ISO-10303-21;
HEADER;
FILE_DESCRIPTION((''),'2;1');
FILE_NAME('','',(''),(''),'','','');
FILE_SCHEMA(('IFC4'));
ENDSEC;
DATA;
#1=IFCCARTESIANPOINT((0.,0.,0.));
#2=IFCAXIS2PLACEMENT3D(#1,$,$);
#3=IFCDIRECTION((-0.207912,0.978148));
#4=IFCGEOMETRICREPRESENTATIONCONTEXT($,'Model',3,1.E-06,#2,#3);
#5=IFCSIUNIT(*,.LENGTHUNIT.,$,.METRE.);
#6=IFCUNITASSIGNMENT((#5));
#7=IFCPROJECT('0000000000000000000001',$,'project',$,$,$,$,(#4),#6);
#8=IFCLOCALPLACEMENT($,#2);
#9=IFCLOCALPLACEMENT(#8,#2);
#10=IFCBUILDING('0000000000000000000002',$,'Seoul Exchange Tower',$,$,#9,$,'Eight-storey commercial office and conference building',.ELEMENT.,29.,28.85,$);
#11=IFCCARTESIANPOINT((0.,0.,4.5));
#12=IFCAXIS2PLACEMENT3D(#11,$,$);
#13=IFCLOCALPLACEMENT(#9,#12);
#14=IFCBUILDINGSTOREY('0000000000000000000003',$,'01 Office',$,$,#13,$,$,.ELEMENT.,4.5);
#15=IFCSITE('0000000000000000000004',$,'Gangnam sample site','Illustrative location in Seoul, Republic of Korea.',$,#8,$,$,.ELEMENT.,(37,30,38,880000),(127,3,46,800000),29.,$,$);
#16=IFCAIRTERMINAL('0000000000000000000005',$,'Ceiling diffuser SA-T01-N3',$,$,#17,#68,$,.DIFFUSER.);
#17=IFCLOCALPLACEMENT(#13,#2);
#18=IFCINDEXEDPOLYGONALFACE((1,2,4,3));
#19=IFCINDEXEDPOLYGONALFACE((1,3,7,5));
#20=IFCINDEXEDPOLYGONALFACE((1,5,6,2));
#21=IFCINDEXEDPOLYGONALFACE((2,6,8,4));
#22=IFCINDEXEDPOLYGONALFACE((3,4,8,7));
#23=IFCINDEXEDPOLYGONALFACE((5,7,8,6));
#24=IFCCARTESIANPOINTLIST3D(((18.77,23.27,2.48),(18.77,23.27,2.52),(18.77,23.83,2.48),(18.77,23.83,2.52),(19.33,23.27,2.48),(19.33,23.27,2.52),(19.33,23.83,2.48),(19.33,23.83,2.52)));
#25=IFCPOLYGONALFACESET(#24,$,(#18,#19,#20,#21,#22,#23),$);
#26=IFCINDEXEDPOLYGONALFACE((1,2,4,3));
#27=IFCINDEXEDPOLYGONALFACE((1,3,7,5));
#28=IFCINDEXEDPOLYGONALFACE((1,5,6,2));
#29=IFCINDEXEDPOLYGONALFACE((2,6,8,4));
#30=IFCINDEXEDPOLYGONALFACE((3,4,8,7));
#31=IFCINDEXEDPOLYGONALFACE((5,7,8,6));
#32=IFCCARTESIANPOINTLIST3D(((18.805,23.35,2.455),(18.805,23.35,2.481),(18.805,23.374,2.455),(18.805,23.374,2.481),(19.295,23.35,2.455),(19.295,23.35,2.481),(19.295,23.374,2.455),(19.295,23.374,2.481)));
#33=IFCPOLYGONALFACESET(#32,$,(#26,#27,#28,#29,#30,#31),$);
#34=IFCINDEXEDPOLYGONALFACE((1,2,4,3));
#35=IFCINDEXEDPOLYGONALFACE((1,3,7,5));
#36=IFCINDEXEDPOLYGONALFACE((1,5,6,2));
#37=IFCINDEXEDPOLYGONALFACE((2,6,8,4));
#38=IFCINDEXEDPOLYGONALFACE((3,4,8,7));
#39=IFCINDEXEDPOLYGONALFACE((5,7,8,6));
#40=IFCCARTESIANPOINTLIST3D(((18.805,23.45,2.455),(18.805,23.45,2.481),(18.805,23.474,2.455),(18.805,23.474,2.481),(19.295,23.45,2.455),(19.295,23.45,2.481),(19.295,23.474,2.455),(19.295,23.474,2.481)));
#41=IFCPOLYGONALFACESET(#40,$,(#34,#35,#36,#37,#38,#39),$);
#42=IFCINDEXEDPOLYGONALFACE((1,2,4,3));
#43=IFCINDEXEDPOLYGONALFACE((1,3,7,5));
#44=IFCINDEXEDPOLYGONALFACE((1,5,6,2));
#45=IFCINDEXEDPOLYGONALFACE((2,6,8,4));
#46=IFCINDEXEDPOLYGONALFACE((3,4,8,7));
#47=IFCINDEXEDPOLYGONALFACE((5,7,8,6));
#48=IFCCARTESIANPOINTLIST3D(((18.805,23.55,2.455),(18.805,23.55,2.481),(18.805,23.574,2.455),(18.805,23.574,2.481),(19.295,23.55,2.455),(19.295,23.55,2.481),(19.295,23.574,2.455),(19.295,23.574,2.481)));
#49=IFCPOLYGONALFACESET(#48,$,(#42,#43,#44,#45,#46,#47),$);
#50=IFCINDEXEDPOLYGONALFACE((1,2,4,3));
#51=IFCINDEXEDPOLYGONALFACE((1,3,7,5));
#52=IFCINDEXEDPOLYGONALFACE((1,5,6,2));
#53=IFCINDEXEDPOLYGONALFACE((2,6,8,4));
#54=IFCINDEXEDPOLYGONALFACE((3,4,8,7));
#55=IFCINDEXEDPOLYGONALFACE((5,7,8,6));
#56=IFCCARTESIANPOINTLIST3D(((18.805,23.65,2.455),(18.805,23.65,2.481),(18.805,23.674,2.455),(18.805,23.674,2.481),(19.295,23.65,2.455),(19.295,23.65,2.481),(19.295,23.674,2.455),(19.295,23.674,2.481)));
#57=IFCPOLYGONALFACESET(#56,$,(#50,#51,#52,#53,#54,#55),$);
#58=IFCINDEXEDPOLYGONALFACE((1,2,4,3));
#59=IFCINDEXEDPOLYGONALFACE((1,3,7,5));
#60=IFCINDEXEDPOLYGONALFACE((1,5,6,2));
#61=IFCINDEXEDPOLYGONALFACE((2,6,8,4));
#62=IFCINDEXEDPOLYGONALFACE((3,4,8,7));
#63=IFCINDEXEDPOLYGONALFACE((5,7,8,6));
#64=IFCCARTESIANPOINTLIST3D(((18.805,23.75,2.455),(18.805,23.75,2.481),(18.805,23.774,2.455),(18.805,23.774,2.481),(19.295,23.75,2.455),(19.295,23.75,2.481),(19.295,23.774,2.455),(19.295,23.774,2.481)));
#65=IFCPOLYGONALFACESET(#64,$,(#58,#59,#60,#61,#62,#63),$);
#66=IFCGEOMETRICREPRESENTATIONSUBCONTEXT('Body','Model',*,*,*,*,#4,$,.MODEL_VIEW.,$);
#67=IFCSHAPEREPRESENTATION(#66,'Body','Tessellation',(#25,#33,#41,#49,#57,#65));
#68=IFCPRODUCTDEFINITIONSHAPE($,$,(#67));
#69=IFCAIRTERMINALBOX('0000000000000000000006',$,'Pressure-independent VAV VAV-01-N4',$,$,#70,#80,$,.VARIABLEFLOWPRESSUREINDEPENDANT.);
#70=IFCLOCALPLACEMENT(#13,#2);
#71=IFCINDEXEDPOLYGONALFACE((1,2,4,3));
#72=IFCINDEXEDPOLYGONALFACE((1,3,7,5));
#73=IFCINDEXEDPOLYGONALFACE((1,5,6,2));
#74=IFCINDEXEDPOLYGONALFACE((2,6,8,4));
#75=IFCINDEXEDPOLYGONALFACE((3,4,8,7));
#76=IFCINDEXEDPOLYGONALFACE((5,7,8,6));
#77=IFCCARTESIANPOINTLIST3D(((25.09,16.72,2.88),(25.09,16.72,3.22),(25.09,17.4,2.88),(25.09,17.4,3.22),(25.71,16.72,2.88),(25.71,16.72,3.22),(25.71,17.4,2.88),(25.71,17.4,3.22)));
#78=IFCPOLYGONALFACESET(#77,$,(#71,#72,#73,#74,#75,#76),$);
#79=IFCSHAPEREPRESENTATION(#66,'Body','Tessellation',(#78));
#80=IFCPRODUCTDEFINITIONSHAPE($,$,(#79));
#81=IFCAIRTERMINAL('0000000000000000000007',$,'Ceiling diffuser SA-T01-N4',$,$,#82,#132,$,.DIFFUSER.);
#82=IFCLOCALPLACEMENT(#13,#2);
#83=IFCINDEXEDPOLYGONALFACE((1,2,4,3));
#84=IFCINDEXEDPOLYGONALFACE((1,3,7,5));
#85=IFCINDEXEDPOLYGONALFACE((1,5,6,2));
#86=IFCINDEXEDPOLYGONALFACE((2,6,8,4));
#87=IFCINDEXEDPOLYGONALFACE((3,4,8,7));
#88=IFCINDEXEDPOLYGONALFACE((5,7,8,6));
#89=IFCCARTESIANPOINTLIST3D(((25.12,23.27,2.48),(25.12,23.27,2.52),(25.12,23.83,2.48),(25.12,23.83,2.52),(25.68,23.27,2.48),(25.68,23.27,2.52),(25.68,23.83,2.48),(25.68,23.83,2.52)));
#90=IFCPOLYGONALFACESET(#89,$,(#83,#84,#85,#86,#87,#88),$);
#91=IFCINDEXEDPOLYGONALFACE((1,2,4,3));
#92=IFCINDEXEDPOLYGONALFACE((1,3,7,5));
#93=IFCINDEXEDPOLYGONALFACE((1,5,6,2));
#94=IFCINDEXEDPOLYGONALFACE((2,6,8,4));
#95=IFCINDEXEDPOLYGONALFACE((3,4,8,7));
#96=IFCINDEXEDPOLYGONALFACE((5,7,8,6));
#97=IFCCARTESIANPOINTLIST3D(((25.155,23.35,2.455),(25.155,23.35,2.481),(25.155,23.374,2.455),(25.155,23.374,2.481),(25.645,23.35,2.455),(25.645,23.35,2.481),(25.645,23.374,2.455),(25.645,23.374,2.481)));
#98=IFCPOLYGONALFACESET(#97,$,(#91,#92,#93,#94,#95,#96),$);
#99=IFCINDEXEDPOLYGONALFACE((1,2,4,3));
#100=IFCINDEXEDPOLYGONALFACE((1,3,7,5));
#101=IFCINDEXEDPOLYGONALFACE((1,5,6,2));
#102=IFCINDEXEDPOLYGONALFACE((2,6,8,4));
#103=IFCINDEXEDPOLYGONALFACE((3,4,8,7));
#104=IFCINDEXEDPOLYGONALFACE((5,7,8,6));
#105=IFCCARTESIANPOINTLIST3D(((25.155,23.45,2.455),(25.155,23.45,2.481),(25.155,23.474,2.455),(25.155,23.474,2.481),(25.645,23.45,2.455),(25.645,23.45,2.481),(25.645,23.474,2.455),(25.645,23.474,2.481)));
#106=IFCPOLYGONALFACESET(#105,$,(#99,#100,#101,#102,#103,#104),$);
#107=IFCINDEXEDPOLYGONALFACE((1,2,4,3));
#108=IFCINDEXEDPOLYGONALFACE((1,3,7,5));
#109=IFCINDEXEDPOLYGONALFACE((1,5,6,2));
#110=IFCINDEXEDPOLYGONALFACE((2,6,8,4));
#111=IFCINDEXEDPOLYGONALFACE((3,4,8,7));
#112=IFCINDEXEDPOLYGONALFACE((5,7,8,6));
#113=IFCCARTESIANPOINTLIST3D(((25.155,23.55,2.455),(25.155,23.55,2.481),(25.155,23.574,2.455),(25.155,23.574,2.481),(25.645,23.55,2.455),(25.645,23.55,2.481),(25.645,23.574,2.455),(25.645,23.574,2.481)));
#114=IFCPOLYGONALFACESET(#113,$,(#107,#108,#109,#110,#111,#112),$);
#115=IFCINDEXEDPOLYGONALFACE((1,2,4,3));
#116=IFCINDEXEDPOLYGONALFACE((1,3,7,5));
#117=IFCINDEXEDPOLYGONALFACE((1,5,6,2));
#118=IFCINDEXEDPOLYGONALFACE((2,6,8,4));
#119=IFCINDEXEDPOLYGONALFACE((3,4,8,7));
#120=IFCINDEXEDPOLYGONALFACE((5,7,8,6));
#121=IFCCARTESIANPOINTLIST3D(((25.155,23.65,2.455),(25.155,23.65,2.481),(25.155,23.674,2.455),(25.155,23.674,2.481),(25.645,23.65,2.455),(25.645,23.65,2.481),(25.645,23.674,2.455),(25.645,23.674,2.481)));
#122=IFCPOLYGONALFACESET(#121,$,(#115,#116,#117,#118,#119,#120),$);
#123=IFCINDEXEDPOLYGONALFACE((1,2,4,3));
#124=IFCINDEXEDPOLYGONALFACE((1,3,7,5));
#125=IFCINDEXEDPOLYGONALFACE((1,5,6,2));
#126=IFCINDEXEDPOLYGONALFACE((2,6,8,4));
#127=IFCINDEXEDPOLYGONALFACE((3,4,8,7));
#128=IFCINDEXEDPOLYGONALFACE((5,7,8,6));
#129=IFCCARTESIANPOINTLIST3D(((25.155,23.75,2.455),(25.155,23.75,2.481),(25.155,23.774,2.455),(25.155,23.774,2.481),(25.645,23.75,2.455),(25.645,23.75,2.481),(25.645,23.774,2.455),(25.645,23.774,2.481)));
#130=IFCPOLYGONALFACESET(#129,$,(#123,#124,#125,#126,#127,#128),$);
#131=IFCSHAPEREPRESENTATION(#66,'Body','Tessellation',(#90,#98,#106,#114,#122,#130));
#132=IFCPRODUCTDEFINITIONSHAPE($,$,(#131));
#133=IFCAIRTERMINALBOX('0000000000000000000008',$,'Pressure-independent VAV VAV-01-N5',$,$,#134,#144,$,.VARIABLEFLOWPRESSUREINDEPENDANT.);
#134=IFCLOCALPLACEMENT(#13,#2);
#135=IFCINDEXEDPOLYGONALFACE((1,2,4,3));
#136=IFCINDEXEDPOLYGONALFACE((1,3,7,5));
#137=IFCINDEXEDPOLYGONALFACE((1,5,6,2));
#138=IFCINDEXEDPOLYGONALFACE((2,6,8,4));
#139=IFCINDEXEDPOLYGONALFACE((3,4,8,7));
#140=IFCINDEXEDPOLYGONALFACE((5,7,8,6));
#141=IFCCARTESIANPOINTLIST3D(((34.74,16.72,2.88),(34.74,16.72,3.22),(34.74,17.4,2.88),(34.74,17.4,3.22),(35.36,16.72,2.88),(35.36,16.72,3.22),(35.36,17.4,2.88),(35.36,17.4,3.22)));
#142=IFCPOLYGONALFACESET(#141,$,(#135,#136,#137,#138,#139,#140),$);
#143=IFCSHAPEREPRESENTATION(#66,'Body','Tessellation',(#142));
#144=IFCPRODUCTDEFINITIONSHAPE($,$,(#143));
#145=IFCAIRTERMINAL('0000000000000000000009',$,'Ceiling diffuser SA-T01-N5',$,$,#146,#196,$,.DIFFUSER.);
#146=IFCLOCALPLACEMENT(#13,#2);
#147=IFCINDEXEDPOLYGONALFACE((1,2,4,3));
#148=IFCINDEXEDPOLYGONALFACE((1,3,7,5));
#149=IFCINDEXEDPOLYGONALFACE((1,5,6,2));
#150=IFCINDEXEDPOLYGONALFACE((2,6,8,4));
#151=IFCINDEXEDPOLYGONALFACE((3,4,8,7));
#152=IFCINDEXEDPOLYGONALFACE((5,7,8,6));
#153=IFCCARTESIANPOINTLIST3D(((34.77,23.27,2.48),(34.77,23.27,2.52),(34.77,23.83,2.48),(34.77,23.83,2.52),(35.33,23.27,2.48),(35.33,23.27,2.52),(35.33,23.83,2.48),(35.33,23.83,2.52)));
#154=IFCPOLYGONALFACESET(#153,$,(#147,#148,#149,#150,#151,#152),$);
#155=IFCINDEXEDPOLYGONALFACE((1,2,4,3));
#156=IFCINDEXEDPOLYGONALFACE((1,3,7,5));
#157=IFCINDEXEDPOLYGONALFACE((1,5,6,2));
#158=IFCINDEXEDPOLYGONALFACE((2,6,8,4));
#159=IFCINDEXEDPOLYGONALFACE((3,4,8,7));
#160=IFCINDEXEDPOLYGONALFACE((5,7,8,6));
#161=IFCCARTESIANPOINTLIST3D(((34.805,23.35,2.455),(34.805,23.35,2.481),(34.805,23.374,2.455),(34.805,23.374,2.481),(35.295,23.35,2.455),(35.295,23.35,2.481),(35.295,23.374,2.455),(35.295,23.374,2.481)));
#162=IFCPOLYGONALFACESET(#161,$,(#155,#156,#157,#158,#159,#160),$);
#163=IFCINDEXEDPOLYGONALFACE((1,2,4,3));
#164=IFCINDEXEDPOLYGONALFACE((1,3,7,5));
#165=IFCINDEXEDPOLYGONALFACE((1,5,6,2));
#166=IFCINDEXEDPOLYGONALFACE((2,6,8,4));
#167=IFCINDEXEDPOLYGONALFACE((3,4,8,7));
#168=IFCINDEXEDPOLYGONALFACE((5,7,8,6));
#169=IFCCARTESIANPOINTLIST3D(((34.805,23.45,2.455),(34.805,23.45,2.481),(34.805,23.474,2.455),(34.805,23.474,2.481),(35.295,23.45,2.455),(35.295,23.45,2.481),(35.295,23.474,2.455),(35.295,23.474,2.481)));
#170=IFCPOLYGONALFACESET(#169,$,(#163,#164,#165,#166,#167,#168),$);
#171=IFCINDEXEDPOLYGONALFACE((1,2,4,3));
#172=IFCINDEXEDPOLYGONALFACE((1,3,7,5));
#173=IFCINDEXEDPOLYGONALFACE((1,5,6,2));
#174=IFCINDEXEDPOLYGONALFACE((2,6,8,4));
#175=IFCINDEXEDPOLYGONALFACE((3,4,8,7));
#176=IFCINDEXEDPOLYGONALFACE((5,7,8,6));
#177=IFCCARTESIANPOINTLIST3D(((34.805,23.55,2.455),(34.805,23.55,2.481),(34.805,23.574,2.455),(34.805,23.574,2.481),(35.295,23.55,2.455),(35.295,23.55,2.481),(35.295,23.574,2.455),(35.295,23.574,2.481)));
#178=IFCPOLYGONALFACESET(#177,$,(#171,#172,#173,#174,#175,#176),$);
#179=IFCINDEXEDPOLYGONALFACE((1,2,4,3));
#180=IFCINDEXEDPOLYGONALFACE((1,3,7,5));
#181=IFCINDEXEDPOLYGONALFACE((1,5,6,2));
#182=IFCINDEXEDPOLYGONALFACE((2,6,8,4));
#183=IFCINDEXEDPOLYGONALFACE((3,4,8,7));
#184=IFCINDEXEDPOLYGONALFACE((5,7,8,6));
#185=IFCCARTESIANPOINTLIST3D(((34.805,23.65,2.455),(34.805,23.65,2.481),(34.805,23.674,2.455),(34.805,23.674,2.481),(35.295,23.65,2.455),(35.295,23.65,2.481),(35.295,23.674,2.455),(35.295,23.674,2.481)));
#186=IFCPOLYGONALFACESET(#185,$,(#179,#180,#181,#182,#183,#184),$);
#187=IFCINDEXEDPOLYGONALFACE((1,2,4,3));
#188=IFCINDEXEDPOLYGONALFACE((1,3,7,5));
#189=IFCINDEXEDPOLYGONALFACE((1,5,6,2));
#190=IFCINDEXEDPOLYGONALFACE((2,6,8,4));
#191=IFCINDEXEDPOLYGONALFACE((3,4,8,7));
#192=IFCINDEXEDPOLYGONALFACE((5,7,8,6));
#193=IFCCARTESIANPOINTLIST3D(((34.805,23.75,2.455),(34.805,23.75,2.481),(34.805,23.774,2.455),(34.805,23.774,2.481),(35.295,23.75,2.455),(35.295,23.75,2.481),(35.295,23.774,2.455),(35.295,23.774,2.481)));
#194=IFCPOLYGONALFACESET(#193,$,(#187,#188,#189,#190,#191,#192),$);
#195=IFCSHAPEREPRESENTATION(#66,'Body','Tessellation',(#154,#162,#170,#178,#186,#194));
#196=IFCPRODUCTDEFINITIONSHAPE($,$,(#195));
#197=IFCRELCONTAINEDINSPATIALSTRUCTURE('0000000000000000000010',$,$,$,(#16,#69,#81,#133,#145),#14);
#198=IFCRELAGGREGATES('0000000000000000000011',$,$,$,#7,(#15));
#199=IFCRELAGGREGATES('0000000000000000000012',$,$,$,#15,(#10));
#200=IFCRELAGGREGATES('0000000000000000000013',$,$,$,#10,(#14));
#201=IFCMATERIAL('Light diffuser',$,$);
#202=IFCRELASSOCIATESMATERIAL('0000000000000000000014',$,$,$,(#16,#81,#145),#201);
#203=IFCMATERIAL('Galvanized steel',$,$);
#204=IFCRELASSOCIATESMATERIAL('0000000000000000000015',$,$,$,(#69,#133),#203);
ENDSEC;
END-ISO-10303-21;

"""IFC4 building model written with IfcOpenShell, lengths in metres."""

from ifc_helpers import new_model, si_unit, direction, frame, frame_2d, origin, place, context, subcontext, project, spatial, rectangle, extrude, material, element, save


model = new_model("IFC4")

# Units and contexts
model_context = context("Model", 3, precision=1e-06, world=origin(), true_north=direction((-0.207912, 0.978148)))
body_context = subcontext(model_context, "Body", "Model", "MODEL_VIEW")
ifc_project = project(units=[si_unit("LENGTHUNIT", "METRE")], contexts=[model_context])

# Site, building, storey
site_placement = place(None, origin())
site = spatial("IfcSite", under=ifc_project, at=site_placement, Name="Gangnam sample site", Description="Illustrative location in Seoul, Republic of Korea.", CompositionType="ELEMENT", RefLatitude=(37, 30, 38, 880000), RefLongitude=(127, 3, 46, 800000), RefElevation=29.0)
building_placement = place(site_placement, origin())
building = spatial("IfcBuilding", under=site, at=building_placement, Name="Seoul Exchange Tower", LongName="Eight-storey commercial office and conference building", CompositionType="ELEMENT", ElevationOfRefHeight=29.0, ElevationOfTerrain=28.85)
storey_placement = place(building_placement, frame((0.0, 0.0, 4.5)))
storey = spatial("IfcBuildingStorey", under=building, at=storey_placement, Name="01 Office", CompositionType="ELEMENT", Elevation=4.5)

# Shared definitions
placement = place(storey_placement, origin())

# Shared definitions
ifc_material_1 = material(Name="Galvanized steel")

# Shared definitions
ifc_material_2 = material(Name="Light diffuser")

# Air terminal
element("IfcAirTerminal", 1, at=placement, inside=storey, material=ifc_material_2, Name="Ceiling diffuser SA-T01-N3", PredefinedType="DIFFUSER", context=body_context, shape_type="SweptSolid", body=[
    extrude(rectangle(XDim=0.56, YDim=0.56, at=frame_2d((0.28, 0.28))), frame((18.77, 23.27, 2.48)), (0.0, 0.0, 1.0), 0.04),
    extrude(rectangle(XDim=0.49, YDim=0.024, at=frame_2d((0.245, 0.012))), frame((18.805, 23.35, 2.455)), (0.0, 0.0, 1.0), 0.026),
    extrude(rectangle(XDim=0.49, YDim=0.024, at=frame_2d((0.245, 0.012))), frame((18.805, 23.45, 2.455)), (0.0, 0.0, 1.0), 0.026),
    extrude(rectangle(XDim=0.49, YDim=0.024, at=frame_2d((0.245, 0.012))), frame((18.805, 23.55, 2.455)), (0.0, 0.0, 1.0), 0.026),
    extrude(rectangle(XDim=0.49, YDim=0.024, at=frame_2d((0.245, 0.012))), frame((18.805, 23.65, 2.455)), (0.0, 0.0, 1.0), 0.026),
    extrude(rectangle(XDim=0.49, YDim=0.024, at=frame_2d((0.245, 0.012))), frame((18.805, 23.75, 2.455)), (0.0, 0.0, 1.0), 0.026),
])

# Air terminal box
element("IfcAirTerminalBox", 2, at=placement, inside=storey, material=ifc_material_1, Name="Pressure-independent VAV VAV-01-N4", PredefinedType="VARIABLEFLOWPRESSUREINDEPENDANT", context=body_context, shape_type="SweptSolid", body=[
    extrude(rectangle(XDim=0.62, YDim=0.68, at=frame_2d((0.31, 0.34))), frame((25.09, 16.72, 2.88)), (0.0, 0.0, 1.0), 0.34),
])

# Air terminal
element("IfcAirTerminal", 3, at=placement, inside=storey, material=ifc_material_2, Name="Ceiling diffuser SA-T01-N4", PredefinedType="DIFFUSER", context=body_context, shape_type="SweptSolid", body=[
    extrude(rectangle(XDim=0.56, YDim=0.56, at=frame_2d((0.28, 0.28))), frame((25.12, 23.27, 2.48)), (0.0, 0.0, 1.0), 0.04),
    extrude(rectangle(XDim=0.49, YDim=0.024, at=frame_2d((0.245, 0.012))), frame((25.155, 23.35, 2.455)), (0.0, 0.0, 1.0), 0.026),
    extrude(rectangle(XDim=0.49, YDim=0.024, at=frame_2d((0.245, 0.012))), frame((25.155, 23.45, 2.455)), (0.0, 0.0, 1.0), 0.026),
    extrude(rectangle(XDim=0.49, YDim=0.024, at=frame_2d((0.245, 0.012))), frame((25.155, 23.55, 2.455)), (0.0, 0.0, 1.0), 0.026),
    extrude(rectangle(XDim=0.49, YDim=0.024, at=frame_2d((0.245, 0.012))), frame((25.155, 23.65, 2.455)), (0.0, 0.0, 1.0), 0.026),
    extrude(rectangle(XDim=0.49, YDim=0.024, at=frame_2d((0.245, 0.012))), frame((25.155, 23.75, 2.455)), (0.0, 0.0, 1.0), 0.026),
])

# Air terminal box
element("IfcAirTerminalBox", 4, at=placement, inside=storey, material=ifc_material_1, Name="Pressure-independent VAV VAV-01-N5", PredefinedType="VARIABLEFLOWPRESSUREINDEPENDANT", context=body_context, shape_type="SweptSolid", body=[
    extrude(rectangle(XDim=0.62, YDim=0.68, at=frame_2d((0.31, 0.34))), frame((34.74, 16.72, 2.88)), (0.0, 0.0, 1.0), 0.34),
])

# Air terminal
element("IfcAirTerminal", 5, at=placement, inside=storey, material=ifc_material_2, Name="Ceiling diffuser SA-T01-N5", PredefinedType="DIFFUSER", context=body_context, shape_type="SweptSolid", body=[
    extrude(rectangle(XDim=0.56, YDim=0.56, at=frame_2d((0.28, 0.28))), frame((34.77, 23.27, 2.48)), (0.0, 0.0, 1.0), 0.04),
    extrude(rectangle(XDim=0.49, YDim=0.024, at=frame_2d((0.245, 0.012))), frame((34.805, 23.35, 2.455)), (0.0, 0.0, 1.0), 0.026),
    extrude(rectangle(XDim=0.49, YDim=0.024, at=frame_2d((0.245, 0.012))), frame((34.805, 23.45, 2.455)), (0.0, 0.0, 1.0), 0.026),
    extrude(rectangle(XDim=0.49, YDim=0.024, at=frame_2d((0.245, 0.012))), frame((34.805, 23.55, 2.455)), (0.0, 0.0, 1.0), 0.026),
    extrude(rectangle(XDim=0.49, YDim=0.024, at=frame_2d((0.245, 0.012))), frame((34.805, 23.65, 2.455)), (0.0, 0.0, 1.0), 0.026),
    extrude(rectangle(XDim=0.49, YDim=0.024, at=frame_2d((0.245, 0.012))), frame((34.805, 23.75, 2.455)), (0.0, 0.0, 1.0), 0.026),
])

save(model, "model.ifc")
